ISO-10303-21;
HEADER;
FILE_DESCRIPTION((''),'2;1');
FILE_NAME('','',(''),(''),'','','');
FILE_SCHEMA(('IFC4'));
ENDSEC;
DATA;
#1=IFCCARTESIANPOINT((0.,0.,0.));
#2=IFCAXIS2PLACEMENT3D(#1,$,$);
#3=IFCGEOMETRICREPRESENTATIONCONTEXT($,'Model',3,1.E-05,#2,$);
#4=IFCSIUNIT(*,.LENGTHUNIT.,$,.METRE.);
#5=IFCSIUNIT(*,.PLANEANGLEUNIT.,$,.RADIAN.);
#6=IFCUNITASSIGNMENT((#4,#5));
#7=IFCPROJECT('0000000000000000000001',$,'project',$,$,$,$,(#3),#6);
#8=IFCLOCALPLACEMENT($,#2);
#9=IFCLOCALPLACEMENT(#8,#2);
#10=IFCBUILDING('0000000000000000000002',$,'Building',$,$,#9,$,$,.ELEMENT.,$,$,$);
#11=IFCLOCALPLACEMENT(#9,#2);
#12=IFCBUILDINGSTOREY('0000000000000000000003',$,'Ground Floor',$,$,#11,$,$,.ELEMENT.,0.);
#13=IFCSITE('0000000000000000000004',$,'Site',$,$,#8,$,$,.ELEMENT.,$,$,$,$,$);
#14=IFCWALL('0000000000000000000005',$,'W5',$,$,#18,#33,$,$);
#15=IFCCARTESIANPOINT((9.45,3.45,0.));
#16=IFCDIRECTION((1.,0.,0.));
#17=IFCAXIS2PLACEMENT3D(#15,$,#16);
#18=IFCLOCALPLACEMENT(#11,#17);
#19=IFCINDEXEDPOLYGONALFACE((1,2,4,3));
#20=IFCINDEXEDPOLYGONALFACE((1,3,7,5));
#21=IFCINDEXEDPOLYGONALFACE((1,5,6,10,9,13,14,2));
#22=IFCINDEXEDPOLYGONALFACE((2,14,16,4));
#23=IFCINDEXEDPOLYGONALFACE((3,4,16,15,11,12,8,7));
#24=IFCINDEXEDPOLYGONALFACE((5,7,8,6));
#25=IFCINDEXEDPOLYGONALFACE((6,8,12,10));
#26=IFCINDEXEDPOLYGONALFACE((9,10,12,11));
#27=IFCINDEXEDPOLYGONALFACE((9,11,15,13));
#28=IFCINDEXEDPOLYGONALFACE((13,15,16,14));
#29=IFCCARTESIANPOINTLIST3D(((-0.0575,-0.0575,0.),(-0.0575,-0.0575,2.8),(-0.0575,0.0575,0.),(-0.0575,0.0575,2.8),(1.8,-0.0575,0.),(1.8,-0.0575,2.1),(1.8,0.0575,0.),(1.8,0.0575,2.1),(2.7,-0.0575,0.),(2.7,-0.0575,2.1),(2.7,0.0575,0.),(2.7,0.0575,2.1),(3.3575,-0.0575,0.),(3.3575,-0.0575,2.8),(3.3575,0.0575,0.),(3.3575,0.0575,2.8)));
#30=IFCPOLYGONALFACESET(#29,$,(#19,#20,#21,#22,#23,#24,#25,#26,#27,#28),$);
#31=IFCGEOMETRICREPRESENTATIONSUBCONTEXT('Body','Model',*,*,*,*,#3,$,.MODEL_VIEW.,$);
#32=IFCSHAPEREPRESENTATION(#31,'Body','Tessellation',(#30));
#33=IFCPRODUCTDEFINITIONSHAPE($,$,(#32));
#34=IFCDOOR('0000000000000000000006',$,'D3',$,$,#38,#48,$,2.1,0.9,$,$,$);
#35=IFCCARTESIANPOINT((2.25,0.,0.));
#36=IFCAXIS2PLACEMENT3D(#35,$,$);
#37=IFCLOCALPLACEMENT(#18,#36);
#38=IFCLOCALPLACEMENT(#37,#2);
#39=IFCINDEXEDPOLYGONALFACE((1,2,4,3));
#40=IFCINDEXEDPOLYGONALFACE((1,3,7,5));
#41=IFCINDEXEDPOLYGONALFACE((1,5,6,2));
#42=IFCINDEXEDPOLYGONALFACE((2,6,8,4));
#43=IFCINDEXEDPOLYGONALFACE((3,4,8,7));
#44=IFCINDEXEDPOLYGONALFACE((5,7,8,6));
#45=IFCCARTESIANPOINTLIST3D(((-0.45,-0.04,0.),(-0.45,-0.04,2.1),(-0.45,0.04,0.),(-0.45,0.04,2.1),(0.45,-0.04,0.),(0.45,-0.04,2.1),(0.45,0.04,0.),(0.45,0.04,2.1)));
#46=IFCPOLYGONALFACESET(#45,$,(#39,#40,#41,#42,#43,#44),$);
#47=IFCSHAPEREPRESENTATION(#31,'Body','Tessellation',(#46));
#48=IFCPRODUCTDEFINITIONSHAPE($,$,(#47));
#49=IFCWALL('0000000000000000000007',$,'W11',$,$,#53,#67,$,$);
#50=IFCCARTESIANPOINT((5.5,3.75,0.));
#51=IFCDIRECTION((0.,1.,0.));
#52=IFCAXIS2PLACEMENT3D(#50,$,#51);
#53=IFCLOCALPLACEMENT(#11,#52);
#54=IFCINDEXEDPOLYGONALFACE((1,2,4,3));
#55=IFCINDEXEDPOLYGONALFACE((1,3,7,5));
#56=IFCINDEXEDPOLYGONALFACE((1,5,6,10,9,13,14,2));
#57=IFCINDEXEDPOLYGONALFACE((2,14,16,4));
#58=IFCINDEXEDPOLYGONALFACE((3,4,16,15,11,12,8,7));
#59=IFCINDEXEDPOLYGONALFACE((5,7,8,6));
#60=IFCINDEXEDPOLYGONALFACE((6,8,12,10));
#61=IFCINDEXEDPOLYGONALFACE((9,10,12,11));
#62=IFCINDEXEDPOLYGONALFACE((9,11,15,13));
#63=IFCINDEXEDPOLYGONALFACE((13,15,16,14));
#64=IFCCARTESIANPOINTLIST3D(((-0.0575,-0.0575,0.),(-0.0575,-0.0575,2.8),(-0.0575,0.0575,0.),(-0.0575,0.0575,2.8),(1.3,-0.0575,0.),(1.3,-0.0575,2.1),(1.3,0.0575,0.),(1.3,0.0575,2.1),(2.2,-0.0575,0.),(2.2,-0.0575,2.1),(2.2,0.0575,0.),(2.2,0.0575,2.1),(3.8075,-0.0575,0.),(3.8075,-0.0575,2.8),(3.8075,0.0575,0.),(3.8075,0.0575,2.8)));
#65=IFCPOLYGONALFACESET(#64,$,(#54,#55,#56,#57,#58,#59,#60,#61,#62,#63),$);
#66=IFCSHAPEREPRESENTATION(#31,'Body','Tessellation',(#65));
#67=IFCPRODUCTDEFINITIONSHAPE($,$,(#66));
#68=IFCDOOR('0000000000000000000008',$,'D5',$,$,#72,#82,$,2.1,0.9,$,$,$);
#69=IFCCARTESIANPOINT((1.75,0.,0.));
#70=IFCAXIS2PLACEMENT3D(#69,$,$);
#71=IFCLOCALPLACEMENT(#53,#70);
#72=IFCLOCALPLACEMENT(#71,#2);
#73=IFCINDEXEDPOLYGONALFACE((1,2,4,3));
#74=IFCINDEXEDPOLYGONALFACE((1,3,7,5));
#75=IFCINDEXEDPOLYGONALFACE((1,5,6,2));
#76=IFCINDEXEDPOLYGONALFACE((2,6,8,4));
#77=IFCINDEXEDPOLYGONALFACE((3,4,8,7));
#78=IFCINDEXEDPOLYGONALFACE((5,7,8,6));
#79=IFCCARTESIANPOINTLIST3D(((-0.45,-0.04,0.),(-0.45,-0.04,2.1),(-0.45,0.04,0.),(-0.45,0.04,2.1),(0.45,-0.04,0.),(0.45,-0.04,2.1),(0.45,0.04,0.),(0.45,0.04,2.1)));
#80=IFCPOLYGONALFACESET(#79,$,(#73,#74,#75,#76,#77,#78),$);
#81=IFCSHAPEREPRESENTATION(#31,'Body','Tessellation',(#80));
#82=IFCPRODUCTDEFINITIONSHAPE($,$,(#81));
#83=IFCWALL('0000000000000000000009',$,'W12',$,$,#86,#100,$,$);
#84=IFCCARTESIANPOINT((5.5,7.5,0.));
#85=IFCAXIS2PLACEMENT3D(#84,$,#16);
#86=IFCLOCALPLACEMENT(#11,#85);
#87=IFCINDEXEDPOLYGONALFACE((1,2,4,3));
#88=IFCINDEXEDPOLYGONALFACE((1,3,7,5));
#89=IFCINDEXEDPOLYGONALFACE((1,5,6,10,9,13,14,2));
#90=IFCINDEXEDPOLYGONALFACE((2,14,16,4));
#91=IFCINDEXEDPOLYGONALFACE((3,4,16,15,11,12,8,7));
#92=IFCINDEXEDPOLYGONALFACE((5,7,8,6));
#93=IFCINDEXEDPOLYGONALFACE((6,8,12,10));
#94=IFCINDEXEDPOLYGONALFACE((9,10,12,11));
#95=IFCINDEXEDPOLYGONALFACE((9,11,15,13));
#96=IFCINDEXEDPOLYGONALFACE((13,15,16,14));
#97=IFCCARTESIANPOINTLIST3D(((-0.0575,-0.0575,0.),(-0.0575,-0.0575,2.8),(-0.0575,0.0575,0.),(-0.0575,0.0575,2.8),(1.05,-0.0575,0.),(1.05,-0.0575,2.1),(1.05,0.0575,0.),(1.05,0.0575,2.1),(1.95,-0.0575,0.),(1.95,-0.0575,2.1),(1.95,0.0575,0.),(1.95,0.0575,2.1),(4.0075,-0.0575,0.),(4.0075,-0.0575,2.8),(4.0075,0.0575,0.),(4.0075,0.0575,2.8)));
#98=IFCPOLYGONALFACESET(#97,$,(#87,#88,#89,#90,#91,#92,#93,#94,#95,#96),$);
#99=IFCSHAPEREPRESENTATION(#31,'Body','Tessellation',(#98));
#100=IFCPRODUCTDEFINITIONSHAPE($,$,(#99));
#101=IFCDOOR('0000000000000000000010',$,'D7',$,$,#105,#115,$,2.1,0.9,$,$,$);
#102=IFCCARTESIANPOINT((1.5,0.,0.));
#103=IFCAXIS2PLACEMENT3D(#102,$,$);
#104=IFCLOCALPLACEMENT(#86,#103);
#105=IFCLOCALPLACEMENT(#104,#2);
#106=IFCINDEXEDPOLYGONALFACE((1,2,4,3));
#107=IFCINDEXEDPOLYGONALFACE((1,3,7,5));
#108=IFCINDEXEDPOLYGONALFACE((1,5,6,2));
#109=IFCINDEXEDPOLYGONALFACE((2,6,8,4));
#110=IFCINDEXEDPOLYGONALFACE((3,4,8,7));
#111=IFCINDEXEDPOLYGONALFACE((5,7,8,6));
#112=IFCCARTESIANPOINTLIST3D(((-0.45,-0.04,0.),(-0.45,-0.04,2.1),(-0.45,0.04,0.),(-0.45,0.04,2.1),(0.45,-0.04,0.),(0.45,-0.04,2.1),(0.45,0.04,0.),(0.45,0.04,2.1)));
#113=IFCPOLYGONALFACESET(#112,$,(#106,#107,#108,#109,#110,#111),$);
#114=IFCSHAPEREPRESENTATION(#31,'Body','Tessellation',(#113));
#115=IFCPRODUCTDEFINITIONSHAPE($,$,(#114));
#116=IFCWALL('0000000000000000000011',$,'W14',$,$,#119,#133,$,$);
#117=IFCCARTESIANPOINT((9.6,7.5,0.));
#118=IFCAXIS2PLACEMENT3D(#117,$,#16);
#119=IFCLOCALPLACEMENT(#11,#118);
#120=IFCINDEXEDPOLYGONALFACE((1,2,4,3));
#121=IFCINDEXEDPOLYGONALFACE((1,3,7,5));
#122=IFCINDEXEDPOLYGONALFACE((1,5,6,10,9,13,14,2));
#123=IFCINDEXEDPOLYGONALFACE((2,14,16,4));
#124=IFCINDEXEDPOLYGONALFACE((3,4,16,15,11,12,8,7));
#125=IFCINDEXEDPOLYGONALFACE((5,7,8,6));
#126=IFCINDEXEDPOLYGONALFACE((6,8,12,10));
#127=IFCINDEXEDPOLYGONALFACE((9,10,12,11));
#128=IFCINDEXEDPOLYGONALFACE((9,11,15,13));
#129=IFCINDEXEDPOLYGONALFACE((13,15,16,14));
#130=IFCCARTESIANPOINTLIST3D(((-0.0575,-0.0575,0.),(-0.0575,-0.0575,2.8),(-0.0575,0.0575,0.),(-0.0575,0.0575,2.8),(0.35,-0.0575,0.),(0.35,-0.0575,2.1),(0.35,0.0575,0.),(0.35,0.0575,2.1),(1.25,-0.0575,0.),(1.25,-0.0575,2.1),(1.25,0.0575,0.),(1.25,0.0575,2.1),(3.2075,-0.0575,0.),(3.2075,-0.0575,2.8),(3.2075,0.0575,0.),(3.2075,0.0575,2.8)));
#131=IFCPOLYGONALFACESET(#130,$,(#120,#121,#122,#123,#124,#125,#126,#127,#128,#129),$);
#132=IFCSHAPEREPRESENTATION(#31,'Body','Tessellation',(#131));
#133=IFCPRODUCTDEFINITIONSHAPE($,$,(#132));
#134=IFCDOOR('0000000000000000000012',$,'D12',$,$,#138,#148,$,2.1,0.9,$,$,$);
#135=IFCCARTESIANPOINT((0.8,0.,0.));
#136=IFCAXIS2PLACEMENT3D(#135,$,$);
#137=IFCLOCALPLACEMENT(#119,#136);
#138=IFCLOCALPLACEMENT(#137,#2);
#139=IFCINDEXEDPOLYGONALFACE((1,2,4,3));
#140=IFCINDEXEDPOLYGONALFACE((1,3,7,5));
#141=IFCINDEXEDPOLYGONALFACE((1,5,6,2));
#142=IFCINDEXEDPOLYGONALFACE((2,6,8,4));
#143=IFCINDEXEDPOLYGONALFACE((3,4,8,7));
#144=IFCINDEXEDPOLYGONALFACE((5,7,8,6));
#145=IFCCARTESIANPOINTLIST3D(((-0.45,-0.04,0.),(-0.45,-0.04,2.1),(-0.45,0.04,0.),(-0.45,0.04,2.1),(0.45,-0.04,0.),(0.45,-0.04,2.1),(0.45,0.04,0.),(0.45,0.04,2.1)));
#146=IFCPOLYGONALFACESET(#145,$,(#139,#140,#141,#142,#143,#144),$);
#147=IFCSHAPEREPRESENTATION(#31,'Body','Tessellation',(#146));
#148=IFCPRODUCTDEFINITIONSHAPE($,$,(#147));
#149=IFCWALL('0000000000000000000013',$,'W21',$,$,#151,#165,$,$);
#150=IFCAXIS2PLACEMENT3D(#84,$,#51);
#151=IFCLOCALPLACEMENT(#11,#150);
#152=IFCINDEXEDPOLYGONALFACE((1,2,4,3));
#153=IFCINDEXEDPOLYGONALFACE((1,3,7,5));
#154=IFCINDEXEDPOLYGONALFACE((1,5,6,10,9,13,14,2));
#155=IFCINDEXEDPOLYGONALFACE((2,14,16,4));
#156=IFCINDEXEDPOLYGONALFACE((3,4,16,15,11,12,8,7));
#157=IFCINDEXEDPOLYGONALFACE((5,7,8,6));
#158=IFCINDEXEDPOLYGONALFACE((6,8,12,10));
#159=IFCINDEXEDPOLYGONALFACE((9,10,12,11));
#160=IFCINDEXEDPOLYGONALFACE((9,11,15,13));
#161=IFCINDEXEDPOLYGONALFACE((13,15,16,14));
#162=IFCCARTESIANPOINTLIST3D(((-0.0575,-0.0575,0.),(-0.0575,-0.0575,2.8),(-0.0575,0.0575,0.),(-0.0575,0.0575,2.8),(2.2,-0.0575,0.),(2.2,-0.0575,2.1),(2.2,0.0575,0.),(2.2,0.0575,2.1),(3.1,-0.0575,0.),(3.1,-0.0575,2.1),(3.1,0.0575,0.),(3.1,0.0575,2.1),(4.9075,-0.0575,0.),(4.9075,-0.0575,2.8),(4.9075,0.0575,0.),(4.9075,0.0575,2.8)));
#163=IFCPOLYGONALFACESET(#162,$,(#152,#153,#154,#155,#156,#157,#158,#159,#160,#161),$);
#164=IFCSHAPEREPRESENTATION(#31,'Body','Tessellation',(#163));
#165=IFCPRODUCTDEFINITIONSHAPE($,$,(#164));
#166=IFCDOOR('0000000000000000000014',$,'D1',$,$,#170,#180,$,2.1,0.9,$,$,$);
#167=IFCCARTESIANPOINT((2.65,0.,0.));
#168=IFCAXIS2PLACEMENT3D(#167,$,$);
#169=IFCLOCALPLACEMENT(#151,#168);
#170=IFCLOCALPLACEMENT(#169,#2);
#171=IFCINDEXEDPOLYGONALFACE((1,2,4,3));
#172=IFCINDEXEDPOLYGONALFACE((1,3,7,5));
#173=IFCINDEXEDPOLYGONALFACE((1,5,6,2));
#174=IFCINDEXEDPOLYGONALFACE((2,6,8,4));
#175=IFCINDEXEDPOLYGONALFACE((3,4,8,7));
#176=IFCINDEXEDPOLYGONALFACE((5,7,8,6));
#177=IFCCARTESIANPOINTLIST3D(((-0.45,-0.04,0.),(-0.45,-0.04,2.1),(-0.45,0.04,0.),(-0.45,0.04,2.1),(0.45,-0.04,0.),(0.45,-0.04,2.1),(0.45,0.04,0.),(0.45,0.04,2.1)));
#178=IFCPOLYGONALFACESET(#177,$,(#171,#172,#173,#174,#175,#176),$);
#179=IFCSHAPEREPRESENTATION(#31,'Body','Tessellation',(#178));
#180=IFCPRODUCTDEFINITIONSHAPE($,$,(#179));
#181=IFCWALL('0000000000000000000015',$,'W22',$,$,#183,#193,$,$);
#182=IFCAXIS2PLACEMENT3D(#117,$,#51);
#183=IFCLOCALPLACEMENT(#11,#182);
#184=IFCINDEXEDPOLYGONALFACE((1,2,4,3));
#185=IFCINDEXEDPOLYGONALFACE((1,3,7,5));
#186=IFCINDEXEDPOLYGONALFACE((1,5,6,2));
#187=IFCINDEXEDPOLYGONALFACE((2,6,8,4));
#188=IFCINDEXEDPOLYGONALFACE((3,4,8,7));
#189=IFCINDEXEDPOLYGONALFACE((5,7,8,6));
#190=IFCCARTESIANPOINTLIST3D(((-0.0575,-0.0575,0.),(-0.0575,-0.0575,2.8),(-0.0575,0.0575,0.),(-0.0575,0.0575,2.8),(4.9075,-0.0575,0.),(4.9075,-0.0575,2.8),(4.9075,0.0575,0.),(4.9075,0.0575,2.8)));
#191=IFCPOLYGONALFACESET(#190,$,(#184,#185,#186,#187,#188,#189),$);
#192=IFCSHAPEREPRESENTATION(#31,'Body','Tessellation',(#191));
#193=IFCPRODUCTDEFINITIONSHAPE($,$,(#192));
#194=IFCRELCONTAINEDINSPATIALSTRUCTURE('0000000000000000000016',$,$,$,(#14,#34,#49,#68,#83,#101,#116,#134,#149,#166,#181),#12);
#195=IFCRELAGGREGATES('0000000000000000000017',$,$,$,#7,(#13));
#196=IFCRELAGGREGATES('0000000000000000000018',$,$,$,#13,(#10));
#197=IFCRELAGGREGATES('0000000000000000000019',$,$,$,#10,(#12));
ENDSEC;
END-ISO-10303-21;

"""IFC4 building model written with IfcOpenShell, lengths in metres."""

from ifc_helpers import new_model, si_unit, frame, frame_2d, origin, origin_2d, place, context, subcontext, project, spatial, rectangle, extrude, element, fill, save


model = new_model("IFC4")

# Units and contexts
model_context = context("Model", 3, precision=1e-05, world=origin())
body_context = subcontext(model_context, "Body", "Model", "MODEL_VIEW")
ifc_project = project(units=[si_unit("LENGTHUNIT", "METRE"), si_unit("PLANEANGLEUNIT", "RADIAN")], contexts=[model_context])

# Site, building, storey
site_placement = place(None, origin())
site = spatial("IfcSite", under=ifc_project, at=site_placement, Name="Site", CompositionType="ELEMENT")
building_placement = place(site_placement, origin())
building = spatial("IfcBuilding", under=site, at=building_placement, Name="Building", CompositionType="ELEMENT")
storey_placement = place(building_placement, origin())
storey = spatial("IfcBuildingStorey", under=building, at=storey_placement, Name="Ground Floor", CompositionType="ELEMENT", Elevation=0.0)

# Walls, openings, doors
wall_1_placement = place(storey_placement, frame((9.45, 3.45, 0.0), x_axis=(1.0, 0.0, 0.0)))
wall_1 = element("IfcWall", 1, at=wall_1_placement, inside=storey, Name="W5", context=body_context, shape_type="SweptSolid", body=[
    extrude(rectangle(XDim=3.415, YDim=0.115, at=frame_2d((1.65, 0.0))), origin(), (0.0, 0.0, 1.0), 2.8),
])
opening_1_placement = place(wall_1_placement, frame((2.25, 0.0, 0.0)))
opening_1 = element("IfcOpeningElement", 2, at=opening_1_placement, cuts=wall_1, context=body_context, shape_type="SweptSolid", body=[
    extrude(rectangle(XDim=0.9, YDim=0.215, at=origin_2d()), origin(), (0.0, 0.0, 1.0), 2.1),
])
door_1_placement = place(opening_1_placement, origin())
door_1 = element("IfcDoor", 3, at=door_1_placement, inside=storey, Name="D3", OverallHeight=2.1, OverallWidth=0.9, context=body_context, shape_type="SweptSolid", body=[
    extrude(rectangle(XDim=0.9, YDim=0.08, at=origin_2d()), origin(), (0.0, 0.0, 1.0), 2.1),
])
fill(opening_1, door_1)
wall_2_placement = place(storey_placement, frame((5.5, 3.75, 0.0), x_axis=(0.0, 1.0, 0.0)))
wall_2 = element("IfcWall", 4, at=wall_2_placement, inside=storey, Name="W11", context=body_context, shape_type="SweptSolid", body=[
    extrude(rectangle(XDim=3.865, YDim=0.115, at=frame_2d((1.875, 0.0))), origin(), (0.0, 0.0, 1.0), 2.8),
])
opening_2_placement = place(wall_2_placement, frame((1.75, 0.0, 0.0)))
opening_2 = element("IfcOpeningElement", 5, at=opening_2_placement, cuts=wall_2, context=body_context, shape_type="SweptSolid", body=[
    extrude(rectangle(XDim=0.9, YDim=0.215, at=origin_2d()), origin(), (0.0, 0.0, 1.0), 2.1),
])
door_2_placement = place(opening_2_placement, origin())
door_2 = element("IfcDoor", 6, at=door_2_placement, inside=storey, Name="D5", OverallHeight=2.1, OverallWidth=0.9, context=body_context, shape_type="SweptSolid", body=[
    extrude(rectangle(XDim=0.9, YDim=0.08, at=origin_2d()), origin(), (0.0, 0.0, 1.0), 2.1),
])
fill(opening_2, door_2)
wall_3_placement = place(storey_placement, frame((5.5, 7.5, 0.0), x_axis=(1.0, 0.0, 0.0)))
wall_3 = element("IfcWall", 7, at=wall_3_placement, inside=storey, Name="W12", context=body_context, shape_type="SweptSolid", body=[
    extrude(rectangle(XDim=4.065, YDim=0.115, at=frame_2d((1.975, 0.0))), origin(), (0.0, 0.0, 1.0), 2.8),
])
opening_3_placement = place(wall_3_placement, frame((1.5, 0.0, 0.0)))
opening_3 = element("IfcOpeningElement", 8, at=opening_3_placement, cuts=wall_3, context=body_context, shape_type="SweptSolid", body=[
    extrude(rectangle(XDim=0.9, YDim=0.215, at=origin_2d()), origin(), (0.0, 0.0, 1.0), 2.1),
])
door_3_placement = place(opening_3_placement, origin())
door_3 = element("IfcDoor", 9, at=door_3_placement, inside=storey, Name="D7", OverallHeight=2.1, OverallWidth=0.9, context=body_context, shape_type="SweptSolid", body=[
    extrude(rectangle(XDim=0.9, YDim=0.08, at=origin_2d()), origin(), (0.0, 0.0, 1.0), 2.1),
])
fill(opening_3, door_3)
wall_4_placement = place(storey_placement, frame((9.6, 7.5, 0.0), x_axis=(1.0, 0.0, 0.0)))
wall_4 = element("IfcWall", 10, at=wall_4_placement, inside=storey, Name="W14", context=body_context, shape_type="SweptSolid", body=[
    extrude(rectangle(XDim=3.265, YDim=0.115, at=frame_2d((1.575, 0.0))), origin(), (0.0, 0.0, 1.0), 2.8),
])
opening_4_placement = place(wall_4_placement, frame((0.8, 0.0, 0.0)))
opening_4 = element("IfcOpeningElement", 11, at=opening_4_placement, cuts=wall_4, context=body_context, shape_type="SweptSolid", body=[
    extrude(rectangle(XDim=0.9, YDim=0.215, at=origin_2d()), origin(), (0.0, 0.0, 1.0), 2.1),
])
door_4_placement = place(opening_4_placement, origin())
door_4 = element("IfcDoor", 12, at=door_4_placement, inside=storey, Name="D12", OverallHeight=2.1, OverallWidth=0.9, context=body_context, shape_type="SweptSolid", body=[
    extrude(rectangle(XDim=0.9, YDim=0.08, at=origin_2d()), origin(), (0.0, 0.0, 1.0), 2.1),
])
fill(opening_4, door_4)
wall_5_placement = place(storey_placement, frame((5.5, 7.5, 0.0), x_axis=(0.0, 1.0, 0.0)))
wall_5 = element("IfcWall", 13, at=wall_5_placement, inside=storey, Name="W21", context=body_context, shape_type="SweptSolid", body=[
    extrude(rectangle(XDim=4.965, YDim=0.115, at=frame_2d((2.425, 0.0))), origin(), (0.0, 0.0, 1.0), 2.8),
])
opening_5_placement = place(wall_5_placement, frame((2.65, 0.0, 0.0)))
opening_5 = element("IfcOpeningElement", 14, at=opening_5_placement, cuts=wall_5, context=body_context, shape_type="SweptSolid", body=[
    extrude(rectangle(XDim=0.9, YDim=0.215, at=origin_2d()), origin(), (0.0, 0.0, 1.0), 2.1),
])
door_5_placement = place(opening_5_placement, origin())
door_5 = element("IfcDoor", 15, at=door_5_placement, inside=storey, Name="D1", OverallHeight=2.1, OverallWidth=0.9, context=body_context, shape_type="SweptSolid", body=[
    extrude(rectangle(XDim=0.9, YDim=0.08, at=origin_2d()), origin(), (0.0, 0.0, 1.0), 2.1),
])
fill(opening_5, door_5)

# Wall
wall_6_placement = place(storey_placement, frame((9.6, 7.5, 0.0), x_axis=(0.0, 1.0, 0.0)))
element("IfcWall", 16, at=wall_6_placement, inside=storey, Name="W22", context=body_context, shape_type="SweptSolid", body=[
    extrude(rectangle(XDim=4.965, YDim=0.115, at=frame_2d((2.425, 0.0))), origin(), (0.0, 0.0, 1.0), 2.8),
])

save(model, "model.ifc")
